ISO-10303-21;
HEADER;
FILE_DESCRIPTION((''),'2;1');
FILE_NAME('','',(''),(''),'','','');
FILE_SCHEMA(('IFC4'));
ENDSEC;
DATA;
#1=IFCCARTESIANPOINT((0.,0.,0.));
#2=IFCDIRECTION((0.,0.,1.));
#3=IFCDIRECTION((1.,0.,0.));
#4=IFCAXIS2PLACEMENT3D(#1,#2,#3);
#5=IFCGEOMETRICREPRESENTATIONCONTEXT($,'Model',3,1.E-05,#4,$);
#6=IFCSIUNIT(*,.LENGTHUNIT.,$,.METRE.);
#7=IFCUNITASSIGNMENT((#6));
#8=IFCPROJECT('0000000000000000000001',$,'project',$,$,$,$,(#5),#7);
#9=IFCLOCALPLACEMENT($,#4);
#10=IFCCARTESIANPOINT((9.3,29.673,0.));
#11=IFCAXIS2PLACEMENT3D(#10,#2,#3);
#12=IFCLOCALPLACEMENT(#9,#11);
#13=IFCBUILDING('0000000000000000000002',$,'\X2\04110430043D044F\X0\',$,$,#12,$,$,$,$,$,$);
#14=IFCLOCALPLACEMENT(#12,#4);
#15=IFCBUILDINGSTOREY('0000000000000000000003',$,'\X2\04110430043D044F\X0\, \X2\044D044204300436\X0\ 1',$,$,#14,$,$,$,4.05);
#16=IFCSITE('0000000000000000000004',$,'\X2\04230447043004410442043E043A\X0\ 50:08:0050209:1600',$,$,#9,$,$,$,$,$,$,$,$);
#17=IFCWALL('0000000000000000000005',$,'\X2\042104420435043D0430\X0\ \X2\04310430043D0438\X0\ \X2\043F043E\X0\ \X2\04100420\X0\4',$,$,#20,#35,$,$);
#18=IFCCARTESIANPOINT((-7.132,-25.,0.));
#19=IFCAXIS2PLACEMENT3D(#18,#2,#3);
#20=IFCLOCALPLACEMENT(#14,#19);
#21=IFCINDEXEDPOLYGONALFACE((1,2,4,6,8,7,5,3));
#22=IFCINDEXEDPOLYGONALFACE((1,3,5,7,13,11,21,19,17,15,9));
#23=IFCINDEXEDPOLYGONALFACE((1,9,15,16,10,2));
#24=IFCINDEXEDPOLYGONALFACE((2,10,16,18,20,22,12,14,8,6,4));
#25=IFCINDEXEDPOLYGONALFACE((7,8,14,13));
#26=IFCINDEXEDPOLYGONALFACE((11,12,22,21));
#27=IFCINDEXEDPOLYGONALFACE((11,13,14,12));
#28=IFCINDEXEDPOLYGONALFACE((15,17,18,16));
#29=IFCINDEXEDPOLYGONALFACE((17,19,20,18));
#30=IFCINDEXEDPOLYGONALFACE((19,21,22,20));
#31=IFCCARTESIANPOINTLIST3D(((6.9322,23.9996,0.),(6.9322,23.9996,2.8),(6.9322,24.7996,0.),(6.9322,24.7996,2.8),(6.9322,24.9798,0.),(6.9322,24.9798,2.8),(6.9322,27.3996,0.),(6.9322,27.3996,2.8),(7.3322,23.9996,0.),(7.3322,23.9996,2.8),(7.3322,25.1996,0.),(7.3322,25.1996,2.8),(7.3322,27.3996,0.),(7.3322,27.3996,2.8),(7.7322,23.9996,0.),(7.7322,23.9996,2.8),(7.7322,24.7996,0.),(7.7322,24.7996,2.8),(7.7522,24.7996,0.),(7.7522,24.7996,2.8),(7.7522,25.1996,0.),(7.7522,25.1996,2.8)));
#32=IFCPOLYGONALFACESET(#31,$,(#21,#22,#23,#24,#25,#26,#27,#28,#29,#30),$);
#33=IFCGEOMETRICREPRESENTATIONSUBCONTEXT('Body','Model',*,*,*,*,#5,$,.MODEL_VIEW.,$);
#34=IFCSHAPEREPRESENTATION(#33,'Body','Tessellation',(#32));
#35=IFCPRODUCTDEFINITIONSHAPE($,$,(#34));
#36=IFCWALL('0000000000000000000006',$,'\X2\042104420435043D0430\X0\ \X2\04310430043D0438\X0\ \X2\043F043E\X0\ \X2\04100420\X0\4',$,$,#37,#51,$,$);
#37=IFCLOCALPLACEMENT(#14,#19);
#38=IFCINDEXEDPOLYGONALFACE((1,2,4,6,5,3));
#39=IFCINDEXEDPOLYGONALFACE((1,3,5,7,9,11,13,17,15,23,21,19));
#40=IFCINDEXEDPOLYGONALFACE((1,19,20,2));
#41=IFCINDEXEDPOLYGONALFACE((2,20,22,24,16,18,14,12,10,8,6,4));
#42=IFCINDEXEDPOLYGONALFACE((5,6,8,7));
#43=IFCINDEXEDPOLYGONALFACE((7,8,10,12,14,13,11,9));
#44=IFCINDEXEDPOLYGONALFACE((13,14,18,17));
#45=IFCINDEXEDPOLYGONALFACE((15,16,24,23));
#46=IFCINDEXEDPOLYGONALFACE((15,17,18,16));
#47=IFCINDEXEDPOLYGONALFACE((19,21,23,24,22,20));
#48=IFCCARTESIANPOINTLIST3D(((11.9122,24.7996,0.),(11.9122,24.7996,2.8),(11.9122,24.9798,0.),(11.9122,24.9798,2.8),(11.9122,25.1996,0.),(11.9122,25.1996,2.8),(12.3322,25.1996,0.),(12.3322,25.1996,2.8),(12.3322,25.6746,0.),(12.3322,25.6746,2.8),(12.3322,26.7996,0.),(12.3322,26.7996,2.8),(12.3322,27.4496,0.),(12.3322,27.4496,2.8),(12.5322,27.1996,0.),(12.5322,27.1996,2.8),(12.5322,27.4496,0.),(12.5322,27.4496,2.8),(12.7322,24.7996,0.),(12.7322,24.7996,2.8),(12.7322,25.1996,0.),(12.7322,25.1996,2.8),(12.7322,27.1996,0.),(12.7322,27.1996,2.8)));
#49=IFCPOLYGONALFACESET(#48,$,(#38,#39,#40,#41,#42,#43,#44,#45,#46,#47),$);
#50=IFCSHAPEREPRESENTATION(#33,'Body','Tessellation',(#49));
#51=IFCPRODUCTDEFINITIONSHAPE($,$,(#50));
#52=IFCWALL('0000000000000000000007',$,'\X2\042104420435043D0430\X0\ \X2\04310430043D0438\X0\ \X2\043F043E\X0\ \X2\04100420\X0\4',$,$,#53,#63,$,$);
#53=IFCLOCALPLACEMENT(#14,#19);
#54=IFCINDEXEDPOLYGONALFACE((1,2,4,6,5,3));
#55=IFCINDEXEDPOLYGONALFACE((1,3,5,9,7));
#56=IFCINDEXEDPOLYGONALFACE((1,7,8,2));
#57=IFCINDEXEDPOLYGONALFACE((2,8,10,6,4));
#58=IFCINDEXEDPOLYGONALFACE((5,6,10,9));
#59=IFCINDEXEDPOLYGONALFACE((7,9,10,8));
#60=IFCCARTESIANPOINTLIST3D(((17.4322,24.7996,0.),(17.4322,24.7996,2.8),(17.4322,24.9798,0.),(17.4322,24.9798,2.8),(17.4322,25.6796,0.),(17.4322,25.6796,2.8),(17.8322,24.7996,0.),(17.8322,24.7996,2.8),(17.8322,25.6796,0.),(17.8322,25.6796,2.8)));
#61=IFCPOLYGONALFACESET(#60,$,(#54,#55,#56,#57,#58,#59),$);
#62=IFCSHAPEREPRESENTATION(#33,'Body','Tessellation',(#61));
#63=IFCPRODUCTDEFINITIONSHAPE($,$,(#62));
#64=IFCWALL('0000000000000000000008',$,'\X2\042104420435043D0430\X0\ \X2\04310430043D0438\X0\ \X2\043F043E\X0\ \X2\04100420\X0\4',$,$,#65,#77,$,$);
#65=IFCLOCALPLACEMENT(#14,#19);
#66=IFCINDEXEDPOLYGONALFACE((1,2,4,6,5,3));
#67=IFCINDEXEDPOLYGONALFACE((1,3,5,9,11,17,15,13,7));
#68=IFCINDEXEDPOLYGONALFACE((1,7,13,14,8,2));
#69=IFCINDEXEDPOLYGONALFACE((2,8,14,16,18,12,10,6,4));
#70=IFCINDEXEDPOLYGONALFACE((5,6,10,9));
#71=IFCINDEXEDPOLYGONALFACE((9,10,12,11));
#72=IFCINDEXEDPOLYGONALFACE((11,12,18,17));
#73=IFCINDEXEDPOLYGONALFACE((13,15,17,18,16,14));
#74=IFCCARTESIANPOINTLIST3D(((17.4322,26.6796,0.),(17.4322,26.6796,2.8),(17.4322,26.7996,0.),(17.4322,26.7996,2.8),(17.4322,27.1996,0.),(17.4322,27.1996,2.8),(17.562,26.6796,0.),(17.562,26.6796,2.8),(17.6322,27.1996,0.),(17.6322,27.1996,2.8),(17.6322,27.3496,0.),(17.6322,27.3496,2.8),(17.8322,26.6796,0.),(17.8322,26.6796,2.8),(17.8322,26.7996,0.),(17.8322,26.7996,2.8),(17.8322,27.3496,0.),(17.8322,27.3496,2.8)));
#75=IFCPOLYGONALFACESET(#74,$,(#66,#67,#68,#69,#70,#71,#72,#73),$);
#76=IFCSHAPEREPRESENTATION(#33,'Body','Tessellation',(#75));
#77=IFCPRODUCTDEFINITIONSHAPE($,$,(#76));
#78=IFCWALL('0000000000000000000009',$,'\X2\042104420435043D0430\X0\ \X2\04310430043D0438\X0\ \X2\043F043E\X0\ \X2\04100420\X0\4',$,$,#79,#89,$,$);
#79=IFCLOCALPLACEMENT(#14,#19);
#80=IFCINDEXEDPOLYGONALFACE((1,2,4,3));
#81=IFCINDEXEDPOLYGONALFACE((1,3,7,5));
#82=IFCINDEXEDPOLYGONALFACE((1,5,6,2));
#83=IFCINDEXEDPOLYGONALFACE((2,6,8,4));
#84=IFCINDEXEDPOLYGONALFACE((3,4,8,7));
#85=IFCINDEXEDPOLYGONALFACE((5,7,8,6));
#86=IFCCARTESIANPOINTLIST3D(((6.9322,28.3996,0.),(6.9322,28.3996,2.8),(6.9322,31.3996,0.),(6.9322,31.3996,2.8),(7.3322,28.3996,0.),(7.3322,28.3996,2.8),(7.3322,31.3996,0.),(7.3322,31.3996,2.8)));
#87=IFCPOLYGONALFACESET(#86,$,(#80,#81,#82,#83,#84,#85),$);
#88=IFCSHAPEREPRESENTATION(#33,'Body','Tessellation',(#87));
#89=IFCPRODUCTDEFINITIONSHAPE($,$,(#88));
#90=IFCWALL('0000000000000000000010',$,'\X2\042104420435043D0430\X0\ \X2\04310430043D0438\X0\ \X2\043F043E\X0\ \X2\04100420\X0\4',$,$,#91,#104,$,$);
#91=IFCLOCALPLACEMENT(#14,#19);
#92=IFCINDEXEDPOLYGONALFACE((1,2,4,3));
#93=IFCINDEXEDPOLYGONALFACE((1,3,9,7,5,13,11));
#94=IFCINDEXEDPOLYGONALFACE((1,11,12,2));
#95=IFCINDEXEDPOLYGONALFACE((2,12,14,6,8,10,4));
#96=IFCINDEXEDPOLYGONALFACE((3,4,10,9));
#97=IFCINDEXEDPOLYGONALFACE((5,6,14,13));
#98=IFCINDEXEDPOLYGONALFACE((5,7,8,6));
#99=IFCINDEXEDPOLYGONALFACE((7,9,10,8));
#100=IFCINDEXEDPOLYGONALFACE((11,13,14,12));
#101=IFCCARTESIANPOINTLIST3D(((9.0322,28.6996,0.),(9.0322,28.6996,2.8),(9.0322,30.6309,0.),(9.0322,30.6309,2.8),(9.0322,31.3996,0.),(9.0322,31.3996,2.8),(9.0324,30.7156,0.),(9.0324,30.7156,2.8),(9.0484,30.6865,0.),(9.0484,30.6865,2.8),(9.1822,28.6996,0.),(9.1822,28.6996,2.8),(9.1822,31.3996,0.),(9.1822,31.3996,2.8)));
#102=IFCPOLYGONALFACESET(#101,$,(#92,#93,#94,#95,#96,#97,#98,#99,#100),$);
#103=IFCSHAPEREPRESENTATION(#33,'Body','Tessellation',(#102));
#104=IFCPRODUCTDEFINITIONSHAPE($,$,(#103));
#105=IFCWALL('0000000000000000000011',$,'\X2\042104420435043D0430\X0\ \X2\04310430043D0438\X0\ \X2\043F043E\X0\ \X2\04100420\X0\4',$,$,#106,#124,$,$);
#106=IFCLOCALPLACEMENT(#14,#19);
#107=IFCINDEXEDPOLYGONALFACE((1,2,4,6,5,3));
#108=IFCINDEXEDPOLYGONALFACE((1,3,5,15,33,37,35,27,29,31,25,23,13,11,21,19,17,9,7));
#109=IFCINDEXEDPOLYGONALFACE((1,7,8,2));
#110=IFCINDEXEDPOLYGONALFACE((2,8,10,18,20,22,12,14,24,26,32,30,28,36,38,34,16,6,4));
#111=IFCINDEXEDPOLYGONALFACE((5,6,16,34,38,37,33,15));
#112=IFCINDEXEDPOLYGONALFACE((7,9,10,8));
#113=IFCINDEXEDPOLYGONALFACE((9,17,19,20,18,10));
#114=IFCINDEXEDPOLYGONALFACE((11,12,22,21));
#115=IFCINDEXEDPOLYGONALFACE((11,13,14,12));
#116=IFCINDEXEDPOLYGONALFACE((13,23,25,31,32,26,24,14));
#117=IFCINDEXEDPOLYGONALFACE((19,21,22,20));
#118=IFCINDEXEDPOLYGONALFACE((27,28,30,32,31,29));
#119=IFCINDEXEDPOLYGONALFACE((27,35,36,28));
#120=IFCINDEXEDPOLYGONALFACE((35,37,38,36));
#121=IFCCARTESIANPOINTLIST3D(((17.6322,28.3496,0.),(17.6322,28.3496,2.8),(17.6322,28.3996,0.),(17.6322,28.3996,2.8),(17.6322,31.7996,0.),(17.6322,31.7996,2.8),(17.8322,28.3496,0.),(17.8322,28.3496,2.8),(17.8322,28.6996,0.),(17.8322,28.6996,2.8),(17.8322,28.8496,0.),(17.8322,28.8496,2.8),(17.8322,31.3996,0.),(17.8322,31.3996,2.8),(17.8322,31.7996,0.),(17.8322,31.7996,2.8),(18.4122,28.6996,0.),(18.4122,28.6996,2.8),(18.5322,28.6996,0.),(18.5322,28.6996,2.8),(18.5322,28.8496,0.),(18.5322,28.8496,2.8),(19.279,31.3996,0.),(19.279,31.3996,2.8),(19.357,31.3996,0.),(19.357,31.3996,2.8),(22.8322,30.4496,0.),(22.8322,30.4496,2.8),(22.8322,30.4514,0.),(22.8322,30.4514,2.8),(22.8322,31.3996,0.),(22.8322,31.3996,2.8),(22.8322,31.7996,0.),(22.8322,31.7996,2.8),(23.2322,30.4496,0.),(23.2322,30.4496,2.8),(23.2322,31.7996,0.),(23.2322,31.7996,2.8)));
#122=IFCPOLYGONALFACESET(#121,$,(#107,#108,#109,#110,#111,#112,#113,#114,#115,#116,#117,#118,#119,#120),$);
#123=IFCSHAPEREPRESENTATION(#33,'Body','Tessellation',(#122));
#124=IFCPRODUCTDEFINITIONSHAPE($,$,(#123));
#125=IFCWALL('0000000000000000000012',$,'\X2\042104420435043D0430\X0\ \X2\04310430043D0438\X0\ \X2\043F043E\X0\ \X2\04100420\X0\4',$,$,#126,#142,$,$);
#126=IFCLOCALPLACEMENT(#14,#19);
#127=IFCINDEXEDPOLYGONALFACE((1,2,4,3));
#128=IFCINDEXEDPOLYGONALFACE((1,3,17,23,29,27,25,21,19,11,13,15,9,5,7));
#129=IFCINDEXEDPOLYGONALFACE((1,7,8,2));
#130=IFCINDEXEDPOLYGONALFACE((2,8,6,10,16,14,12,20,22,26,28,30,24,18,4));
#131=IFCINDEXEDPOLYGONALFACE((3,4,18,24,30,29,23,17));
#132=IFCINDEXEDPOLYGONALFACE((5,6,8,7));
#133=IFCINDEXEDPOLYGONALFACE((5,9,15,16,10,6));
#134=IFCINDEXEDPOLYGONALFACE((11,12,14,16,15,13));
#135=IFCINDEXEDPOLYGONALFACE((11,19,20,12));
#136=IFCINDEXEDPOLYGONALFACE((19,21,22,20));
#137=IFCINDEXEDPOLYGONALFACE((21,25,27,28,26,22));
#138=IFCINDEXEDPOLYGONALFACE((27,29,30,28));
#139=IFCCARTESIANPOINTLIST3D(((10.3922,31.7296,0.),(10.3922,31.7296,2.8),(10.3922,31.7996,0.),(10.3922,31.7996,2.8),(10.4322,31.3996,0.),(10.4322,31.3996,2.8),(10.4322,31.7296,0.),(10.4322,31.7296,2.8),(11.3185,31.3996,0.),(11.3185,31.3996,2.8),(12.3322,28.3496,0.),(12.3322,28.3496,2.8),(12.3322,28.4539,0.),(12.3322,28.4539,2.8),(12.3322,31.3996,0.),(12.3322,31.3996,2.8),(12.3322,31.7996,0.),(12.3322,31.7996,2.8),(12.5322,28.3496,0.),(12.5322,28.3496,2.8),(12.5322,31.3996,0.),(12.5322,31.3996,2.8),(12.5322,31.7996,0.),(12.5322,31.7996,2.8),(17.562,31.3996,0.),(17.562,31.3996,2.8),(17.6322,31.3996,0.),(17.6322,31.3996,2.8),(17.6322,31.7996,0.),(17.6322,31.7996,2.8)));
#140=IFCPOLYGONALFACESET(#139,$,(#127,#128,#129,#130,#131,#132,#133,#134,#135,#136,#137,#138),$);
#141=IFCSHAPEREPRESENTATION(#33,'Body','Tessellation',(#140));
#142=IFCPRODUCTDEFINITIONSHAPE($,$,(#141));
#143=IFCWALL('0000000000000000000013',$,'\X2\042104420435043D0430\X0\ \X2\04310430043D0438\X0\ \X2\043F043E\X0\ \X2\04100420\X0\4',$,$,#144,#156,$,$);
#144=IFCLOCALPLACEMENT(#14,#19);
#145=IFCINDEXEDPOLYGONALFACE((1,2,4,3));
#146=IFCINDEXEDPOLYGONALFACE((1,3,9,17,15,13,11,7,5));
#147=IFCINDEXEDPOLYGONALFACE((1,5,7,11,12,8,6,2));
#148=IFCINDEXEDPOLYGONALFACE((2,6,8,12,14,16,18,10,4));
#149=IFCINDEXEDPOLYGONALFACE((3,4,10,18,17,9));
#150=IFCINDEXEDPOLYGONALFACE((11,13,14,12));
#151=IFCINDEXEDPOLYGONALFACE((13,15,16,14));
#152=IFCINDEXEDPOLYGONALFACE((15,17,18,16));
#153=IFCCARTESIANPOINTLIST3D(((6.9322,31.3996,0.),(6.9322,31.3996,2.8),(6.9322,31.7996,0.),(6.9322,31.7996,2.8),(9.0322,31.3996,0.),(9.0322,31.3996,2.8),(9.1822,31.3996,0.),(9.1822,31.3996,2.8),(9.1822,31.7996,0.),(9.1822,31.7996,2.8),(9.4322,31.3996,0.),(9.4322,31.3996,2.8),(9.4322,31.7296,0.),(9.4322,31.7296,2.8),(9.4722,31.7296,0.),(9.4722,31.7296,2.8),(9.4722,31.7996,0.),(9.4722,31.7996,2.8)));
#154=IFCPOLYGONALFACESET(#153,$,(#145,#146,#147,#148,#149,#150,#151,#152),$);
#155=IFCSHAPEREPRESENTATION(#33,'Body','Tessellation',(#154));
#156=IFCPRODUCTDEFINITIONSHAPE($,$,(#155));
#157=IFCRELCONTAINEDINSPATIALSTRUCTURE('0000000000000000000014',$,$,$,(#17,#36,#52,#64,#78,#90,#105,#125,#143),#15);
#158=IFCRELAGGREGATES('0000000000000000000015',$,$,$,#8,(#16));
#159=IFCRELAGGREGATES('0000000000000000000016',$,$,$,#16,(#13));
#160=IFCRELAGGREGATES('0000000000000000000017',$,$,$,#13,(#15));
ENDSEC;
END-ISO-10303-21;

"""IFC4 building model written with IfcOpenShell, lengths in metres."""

from ifc_helpers import new_model, si_unit, frame, origin_with_axes, place, context, subcontext, project, spatial, polyline, outline, extrude, element, save


model = new_model("IFC4")

# Units and contexts
model_context = context("Model", 3, precision=1e-05, world=origin_with_axes())
body_context = subcontext(model_context, "Body", "Model", "MODEL_VIEW")
ifc_project = project(units=[si_unit("LENGTHUNIT", "METRE")], contexts=[model_context])

# Site, building, storey
site_placement = place(None, origin_with_axes())
site = spatial("IfcSite", under=ifc_project, at=site_placement, Name="Участок 50:08:0050209:1600")
building_placement = place(site_placement, frame((9.3, 29.673, 0.0), z_axis=(0.0, 0.0, 1.0), x_axis=(1.0, 0.0, 0.0)))
building = spatial("IfcBuilding", under=site, at=building_placement, Name="Баня")
storey_placement = place(building_placement, origin_with_axes())
storey = spatial("IfcBuildingStorey", under=building, at=storey_placement, Name="Баня, этаж 1", Elevation=4.05)

# Walls
wall_1_placement = place(storey_placement, frame((-7.132, -25.0, 0.0), z_axis=(0.0, 0.0, 1.0), x_axis=(1.0, 0.0, 0.0)))
element("IfcWall", 1, at=wall_1_placement, inside=storey, Name="Стена бани по АР4", context=body_context, shape_type="SweptSolid", body=[
    extrude(outline(polyline([(7.7322, 24.7996), (7.7322, 23.9996), (7.3322, 23.9996), (6.9322, 23.9996), (6.9322, 24.7996), (6.9322, 24.9798), (6.9322, 27.3996), (7.3322, 27.3996), (7.3322, 25.1996), (7.7522, 25.1996), (7.7522, 24.7996), (7.7322, 24.7996)])), origin_with_axes(), (0.0, 0.0, 1.0), 2.8),
])
wall_2_placement = place(storey_placement, frame((-7.132, -25.0, 0.0), z_axis=(0.0, 0.0, 1.0), x_axis=(1.0, 0.0, 0.0)))
element("IfcWall", 2, at=wall_2_placement, inside=storey, Name="Стена бани по АР4", context=body_context, shape_type="SweptSolid", body=[
    extrude(outline(polyline([(12.3322, 26.7996), (12.3322, 27.4496), (12.5322, 27.4496), (12.5322, 27.1996), (12.7322, 27.1996), (12.7322, 25.1996), (12.7322, 24.7996), (11.9122, 24.7996), (11.9122, 24.9798), (11.9122, 25.1996), (12.3322, 25.1996), (12.3322, 25.6746), (12.3322, 26.7996)])), origin_with_axes(), (0.0, 0.0, 1.0), 2.8),
])
wall_3_placement = place(storey_placement, frame((-7.132, -25.0, 0.0), z_axis=(0.0, 0.0, 1.0), x_axis=(1.0, 0.0, 0.0)))
element("IfcWall", 3, at=wall_3_placement, inside=storey, Name="Стена бани по АР4", context=body_context, shape_type="SweptSolid", body=[
    extrude(outline(polyline([(17.4322, 24.7996), (17.4322, 24.9798), (17.4322, 25.6796), (17.8322, 25.6796), (17.8322, 24.7996), (17.4322, 24.7996)])), origin_with_axes(), (0.0, 0.0, 1.0), 2.8),
])
wall_4_placement = place(storey_placement, frame((-7.132, -25.0, 0.0), z_axis=(0.0, 0.0, 1.0), x_axis=(1.0, 0.0, 0.0)))
element("IfcWall", 4, at=wall_4_placement, inside=storey, Name="Стена бани по АР4", context=body_context, shape_type="SweptSolid", body=[
    extrude(outline(polyline([(17.6322, 27.1996), (17.6322, 26.7996), (17.6322, 27.3496), (17.8322, 27.3496), (17.8322, 26.7996), (17.8322, 26.6796), (17.562, 26.6796), (17.4322, 26.6796), (17.4322, 26.7996), (17.4322, 26.7996), (17.4322, 27.1996), (17.6322, 27.1996)])), origin_with_axes(), (0.0, 0.0, 1.0), 2.8),
])
wall_5_placement = place(storey_placement, frame((-7.132, -25.0, 0.0), z_axis=(0.0, 0.0, 1.0), x_axis=(1.0, 0.0, 0.0)))
element("IfcWall", 5, at=wall_5_placement, inside=storey, Name="Стена бани по АР4", context=body_context, shape_type="SweptSolid", body=[
    extrude(outline(polyline([(6.9322, 28.3996), (6.9322, 31.3996), (7.3322, 31.3996), (7.3322, 28.3996), (6.9322, 28.3996)])), origin_with_axes(), (0.0, 0.0, 1.0), 2.8),
])
wall_6_placement = place(storey_placement, frame((-7.132, -25.0, 0.0), z_axis=(0.0, 0.0, 1.0), x_axis=(1.0, 0.0, 0.0)))
element("IfcWall", 6, at=wall_6_placement, inside=storey, Name="Стена бани по АР4", context=body_context, shape_type="SweptSolid", body=[
    extrude(outline(polyline([(9.1822, 31.3996), (9.1822, 28.6996), (9.0322, 28.6996), (9.0322, 30.6309), (9.0484, 30.6865), (9.0324, 30.7156), (9.0322, 31.3996), (9.1822, 31.3996)])), origin_with_axes(), (0.0, 0.0, 1.0), 2.8),
])
wall_7_placement = place(storey_placement, frame((-7.132, -25.0, 0.0), z_axis=(0.0, 0.0, 1.0), x_axis=(1.0, 0.0, 0.0)))
element("IfcWall", 7, at=wall_7_placement, inside=storey, Name="Стена бани по АР4", context=body_context, shape_type="SweptSolid", body=[
    extrude(outline(polyline([(17.6322, 28.3996), (17.6322, 31.7996), (17.8322, 31.7996), (22.8322, 31.7996), (22.8322, 31.7996), (23.2322, 31.7996), (23.2322, 30.4496), (22.8322, 30.4496), (22.8322, 30.4514), (22.8322, 31.3996), (19.357, 31.3996), (19.279, 31.3996), (17.8322, 31.3996), (17.8322, 28.8496), (18.5322, 28.8496), (18.5322, 28.6996), (18.4122, 28.6996), (17.8322, 28.6996), (17.8322, 28.3496), (17.6322, 28.3496), (17.6322, 28.3996)])), origin_with_axes(), (0.0, 0.0, 1.0), 2.8),
])
wall_8_placement = place(storey_placement, frame((-7.132, -25.0, 0.0), z_axis=(0.0, 0.0, 1.0), x_axis=(1.0, 0.0, 0.0)))
element("IfcWall", 8, at=wall_8_placement, inside=storey, Name="Стена бани по АР4", context=body_context, shape_type="SweptSolid", body=[
    extrude(outline(polyline([(10.4322, 31.7296), (10.3922, 31.7296), (10.3922, 31.7996), (12.3322, 31.7996), (12.3322, 31.7996), (12.5322, 31.7996), (17.6322, 31.7996), (17.6322, 31.3996), (17.562, 31.3996), (12.5322, 31.3996), (12.5322, 28.3496), (12.3322, 28.3496), (12.3322, 28.4539), (12.3322, 31.3996), (11.3185, 31.3996), (10.4322, 31.3996), (10.4322, 31.7296)])), origin_with_axes(), (0.0, 0.0, 1.0), 2.8),
])
wall_9_placement = place(storey_placement, frame((-7.132, -25.0, 0.0), z_axis=(0.0, 0.0, 1.0), x_axis=(1.0, 0.0, 0.0)))
element("IfcWall", 9, at=wall_9_placement, inside=storey, Name="Стена бани по АР4", context=body_context, shape_type="SweptSolid", body=[
    extrude(outline(polyline([(9.4722, 31.7996), (9.4722, 31.7296), (9.4322, 31.7296), (9.4322, 31.3996), (9.1822, 31.3996), (9.1822, 31.3996), (9.0322, 31.3996), (6.9322, 31.3996), (6.9322, 31.7996), (9.1822, 31.7996), (9.1822, 31.7996), (9.4722, 31.7996)])), origin_with_axes(), (0.0, 0.0, 1.0), 2.8),
])

save(model, "model.ifc")
